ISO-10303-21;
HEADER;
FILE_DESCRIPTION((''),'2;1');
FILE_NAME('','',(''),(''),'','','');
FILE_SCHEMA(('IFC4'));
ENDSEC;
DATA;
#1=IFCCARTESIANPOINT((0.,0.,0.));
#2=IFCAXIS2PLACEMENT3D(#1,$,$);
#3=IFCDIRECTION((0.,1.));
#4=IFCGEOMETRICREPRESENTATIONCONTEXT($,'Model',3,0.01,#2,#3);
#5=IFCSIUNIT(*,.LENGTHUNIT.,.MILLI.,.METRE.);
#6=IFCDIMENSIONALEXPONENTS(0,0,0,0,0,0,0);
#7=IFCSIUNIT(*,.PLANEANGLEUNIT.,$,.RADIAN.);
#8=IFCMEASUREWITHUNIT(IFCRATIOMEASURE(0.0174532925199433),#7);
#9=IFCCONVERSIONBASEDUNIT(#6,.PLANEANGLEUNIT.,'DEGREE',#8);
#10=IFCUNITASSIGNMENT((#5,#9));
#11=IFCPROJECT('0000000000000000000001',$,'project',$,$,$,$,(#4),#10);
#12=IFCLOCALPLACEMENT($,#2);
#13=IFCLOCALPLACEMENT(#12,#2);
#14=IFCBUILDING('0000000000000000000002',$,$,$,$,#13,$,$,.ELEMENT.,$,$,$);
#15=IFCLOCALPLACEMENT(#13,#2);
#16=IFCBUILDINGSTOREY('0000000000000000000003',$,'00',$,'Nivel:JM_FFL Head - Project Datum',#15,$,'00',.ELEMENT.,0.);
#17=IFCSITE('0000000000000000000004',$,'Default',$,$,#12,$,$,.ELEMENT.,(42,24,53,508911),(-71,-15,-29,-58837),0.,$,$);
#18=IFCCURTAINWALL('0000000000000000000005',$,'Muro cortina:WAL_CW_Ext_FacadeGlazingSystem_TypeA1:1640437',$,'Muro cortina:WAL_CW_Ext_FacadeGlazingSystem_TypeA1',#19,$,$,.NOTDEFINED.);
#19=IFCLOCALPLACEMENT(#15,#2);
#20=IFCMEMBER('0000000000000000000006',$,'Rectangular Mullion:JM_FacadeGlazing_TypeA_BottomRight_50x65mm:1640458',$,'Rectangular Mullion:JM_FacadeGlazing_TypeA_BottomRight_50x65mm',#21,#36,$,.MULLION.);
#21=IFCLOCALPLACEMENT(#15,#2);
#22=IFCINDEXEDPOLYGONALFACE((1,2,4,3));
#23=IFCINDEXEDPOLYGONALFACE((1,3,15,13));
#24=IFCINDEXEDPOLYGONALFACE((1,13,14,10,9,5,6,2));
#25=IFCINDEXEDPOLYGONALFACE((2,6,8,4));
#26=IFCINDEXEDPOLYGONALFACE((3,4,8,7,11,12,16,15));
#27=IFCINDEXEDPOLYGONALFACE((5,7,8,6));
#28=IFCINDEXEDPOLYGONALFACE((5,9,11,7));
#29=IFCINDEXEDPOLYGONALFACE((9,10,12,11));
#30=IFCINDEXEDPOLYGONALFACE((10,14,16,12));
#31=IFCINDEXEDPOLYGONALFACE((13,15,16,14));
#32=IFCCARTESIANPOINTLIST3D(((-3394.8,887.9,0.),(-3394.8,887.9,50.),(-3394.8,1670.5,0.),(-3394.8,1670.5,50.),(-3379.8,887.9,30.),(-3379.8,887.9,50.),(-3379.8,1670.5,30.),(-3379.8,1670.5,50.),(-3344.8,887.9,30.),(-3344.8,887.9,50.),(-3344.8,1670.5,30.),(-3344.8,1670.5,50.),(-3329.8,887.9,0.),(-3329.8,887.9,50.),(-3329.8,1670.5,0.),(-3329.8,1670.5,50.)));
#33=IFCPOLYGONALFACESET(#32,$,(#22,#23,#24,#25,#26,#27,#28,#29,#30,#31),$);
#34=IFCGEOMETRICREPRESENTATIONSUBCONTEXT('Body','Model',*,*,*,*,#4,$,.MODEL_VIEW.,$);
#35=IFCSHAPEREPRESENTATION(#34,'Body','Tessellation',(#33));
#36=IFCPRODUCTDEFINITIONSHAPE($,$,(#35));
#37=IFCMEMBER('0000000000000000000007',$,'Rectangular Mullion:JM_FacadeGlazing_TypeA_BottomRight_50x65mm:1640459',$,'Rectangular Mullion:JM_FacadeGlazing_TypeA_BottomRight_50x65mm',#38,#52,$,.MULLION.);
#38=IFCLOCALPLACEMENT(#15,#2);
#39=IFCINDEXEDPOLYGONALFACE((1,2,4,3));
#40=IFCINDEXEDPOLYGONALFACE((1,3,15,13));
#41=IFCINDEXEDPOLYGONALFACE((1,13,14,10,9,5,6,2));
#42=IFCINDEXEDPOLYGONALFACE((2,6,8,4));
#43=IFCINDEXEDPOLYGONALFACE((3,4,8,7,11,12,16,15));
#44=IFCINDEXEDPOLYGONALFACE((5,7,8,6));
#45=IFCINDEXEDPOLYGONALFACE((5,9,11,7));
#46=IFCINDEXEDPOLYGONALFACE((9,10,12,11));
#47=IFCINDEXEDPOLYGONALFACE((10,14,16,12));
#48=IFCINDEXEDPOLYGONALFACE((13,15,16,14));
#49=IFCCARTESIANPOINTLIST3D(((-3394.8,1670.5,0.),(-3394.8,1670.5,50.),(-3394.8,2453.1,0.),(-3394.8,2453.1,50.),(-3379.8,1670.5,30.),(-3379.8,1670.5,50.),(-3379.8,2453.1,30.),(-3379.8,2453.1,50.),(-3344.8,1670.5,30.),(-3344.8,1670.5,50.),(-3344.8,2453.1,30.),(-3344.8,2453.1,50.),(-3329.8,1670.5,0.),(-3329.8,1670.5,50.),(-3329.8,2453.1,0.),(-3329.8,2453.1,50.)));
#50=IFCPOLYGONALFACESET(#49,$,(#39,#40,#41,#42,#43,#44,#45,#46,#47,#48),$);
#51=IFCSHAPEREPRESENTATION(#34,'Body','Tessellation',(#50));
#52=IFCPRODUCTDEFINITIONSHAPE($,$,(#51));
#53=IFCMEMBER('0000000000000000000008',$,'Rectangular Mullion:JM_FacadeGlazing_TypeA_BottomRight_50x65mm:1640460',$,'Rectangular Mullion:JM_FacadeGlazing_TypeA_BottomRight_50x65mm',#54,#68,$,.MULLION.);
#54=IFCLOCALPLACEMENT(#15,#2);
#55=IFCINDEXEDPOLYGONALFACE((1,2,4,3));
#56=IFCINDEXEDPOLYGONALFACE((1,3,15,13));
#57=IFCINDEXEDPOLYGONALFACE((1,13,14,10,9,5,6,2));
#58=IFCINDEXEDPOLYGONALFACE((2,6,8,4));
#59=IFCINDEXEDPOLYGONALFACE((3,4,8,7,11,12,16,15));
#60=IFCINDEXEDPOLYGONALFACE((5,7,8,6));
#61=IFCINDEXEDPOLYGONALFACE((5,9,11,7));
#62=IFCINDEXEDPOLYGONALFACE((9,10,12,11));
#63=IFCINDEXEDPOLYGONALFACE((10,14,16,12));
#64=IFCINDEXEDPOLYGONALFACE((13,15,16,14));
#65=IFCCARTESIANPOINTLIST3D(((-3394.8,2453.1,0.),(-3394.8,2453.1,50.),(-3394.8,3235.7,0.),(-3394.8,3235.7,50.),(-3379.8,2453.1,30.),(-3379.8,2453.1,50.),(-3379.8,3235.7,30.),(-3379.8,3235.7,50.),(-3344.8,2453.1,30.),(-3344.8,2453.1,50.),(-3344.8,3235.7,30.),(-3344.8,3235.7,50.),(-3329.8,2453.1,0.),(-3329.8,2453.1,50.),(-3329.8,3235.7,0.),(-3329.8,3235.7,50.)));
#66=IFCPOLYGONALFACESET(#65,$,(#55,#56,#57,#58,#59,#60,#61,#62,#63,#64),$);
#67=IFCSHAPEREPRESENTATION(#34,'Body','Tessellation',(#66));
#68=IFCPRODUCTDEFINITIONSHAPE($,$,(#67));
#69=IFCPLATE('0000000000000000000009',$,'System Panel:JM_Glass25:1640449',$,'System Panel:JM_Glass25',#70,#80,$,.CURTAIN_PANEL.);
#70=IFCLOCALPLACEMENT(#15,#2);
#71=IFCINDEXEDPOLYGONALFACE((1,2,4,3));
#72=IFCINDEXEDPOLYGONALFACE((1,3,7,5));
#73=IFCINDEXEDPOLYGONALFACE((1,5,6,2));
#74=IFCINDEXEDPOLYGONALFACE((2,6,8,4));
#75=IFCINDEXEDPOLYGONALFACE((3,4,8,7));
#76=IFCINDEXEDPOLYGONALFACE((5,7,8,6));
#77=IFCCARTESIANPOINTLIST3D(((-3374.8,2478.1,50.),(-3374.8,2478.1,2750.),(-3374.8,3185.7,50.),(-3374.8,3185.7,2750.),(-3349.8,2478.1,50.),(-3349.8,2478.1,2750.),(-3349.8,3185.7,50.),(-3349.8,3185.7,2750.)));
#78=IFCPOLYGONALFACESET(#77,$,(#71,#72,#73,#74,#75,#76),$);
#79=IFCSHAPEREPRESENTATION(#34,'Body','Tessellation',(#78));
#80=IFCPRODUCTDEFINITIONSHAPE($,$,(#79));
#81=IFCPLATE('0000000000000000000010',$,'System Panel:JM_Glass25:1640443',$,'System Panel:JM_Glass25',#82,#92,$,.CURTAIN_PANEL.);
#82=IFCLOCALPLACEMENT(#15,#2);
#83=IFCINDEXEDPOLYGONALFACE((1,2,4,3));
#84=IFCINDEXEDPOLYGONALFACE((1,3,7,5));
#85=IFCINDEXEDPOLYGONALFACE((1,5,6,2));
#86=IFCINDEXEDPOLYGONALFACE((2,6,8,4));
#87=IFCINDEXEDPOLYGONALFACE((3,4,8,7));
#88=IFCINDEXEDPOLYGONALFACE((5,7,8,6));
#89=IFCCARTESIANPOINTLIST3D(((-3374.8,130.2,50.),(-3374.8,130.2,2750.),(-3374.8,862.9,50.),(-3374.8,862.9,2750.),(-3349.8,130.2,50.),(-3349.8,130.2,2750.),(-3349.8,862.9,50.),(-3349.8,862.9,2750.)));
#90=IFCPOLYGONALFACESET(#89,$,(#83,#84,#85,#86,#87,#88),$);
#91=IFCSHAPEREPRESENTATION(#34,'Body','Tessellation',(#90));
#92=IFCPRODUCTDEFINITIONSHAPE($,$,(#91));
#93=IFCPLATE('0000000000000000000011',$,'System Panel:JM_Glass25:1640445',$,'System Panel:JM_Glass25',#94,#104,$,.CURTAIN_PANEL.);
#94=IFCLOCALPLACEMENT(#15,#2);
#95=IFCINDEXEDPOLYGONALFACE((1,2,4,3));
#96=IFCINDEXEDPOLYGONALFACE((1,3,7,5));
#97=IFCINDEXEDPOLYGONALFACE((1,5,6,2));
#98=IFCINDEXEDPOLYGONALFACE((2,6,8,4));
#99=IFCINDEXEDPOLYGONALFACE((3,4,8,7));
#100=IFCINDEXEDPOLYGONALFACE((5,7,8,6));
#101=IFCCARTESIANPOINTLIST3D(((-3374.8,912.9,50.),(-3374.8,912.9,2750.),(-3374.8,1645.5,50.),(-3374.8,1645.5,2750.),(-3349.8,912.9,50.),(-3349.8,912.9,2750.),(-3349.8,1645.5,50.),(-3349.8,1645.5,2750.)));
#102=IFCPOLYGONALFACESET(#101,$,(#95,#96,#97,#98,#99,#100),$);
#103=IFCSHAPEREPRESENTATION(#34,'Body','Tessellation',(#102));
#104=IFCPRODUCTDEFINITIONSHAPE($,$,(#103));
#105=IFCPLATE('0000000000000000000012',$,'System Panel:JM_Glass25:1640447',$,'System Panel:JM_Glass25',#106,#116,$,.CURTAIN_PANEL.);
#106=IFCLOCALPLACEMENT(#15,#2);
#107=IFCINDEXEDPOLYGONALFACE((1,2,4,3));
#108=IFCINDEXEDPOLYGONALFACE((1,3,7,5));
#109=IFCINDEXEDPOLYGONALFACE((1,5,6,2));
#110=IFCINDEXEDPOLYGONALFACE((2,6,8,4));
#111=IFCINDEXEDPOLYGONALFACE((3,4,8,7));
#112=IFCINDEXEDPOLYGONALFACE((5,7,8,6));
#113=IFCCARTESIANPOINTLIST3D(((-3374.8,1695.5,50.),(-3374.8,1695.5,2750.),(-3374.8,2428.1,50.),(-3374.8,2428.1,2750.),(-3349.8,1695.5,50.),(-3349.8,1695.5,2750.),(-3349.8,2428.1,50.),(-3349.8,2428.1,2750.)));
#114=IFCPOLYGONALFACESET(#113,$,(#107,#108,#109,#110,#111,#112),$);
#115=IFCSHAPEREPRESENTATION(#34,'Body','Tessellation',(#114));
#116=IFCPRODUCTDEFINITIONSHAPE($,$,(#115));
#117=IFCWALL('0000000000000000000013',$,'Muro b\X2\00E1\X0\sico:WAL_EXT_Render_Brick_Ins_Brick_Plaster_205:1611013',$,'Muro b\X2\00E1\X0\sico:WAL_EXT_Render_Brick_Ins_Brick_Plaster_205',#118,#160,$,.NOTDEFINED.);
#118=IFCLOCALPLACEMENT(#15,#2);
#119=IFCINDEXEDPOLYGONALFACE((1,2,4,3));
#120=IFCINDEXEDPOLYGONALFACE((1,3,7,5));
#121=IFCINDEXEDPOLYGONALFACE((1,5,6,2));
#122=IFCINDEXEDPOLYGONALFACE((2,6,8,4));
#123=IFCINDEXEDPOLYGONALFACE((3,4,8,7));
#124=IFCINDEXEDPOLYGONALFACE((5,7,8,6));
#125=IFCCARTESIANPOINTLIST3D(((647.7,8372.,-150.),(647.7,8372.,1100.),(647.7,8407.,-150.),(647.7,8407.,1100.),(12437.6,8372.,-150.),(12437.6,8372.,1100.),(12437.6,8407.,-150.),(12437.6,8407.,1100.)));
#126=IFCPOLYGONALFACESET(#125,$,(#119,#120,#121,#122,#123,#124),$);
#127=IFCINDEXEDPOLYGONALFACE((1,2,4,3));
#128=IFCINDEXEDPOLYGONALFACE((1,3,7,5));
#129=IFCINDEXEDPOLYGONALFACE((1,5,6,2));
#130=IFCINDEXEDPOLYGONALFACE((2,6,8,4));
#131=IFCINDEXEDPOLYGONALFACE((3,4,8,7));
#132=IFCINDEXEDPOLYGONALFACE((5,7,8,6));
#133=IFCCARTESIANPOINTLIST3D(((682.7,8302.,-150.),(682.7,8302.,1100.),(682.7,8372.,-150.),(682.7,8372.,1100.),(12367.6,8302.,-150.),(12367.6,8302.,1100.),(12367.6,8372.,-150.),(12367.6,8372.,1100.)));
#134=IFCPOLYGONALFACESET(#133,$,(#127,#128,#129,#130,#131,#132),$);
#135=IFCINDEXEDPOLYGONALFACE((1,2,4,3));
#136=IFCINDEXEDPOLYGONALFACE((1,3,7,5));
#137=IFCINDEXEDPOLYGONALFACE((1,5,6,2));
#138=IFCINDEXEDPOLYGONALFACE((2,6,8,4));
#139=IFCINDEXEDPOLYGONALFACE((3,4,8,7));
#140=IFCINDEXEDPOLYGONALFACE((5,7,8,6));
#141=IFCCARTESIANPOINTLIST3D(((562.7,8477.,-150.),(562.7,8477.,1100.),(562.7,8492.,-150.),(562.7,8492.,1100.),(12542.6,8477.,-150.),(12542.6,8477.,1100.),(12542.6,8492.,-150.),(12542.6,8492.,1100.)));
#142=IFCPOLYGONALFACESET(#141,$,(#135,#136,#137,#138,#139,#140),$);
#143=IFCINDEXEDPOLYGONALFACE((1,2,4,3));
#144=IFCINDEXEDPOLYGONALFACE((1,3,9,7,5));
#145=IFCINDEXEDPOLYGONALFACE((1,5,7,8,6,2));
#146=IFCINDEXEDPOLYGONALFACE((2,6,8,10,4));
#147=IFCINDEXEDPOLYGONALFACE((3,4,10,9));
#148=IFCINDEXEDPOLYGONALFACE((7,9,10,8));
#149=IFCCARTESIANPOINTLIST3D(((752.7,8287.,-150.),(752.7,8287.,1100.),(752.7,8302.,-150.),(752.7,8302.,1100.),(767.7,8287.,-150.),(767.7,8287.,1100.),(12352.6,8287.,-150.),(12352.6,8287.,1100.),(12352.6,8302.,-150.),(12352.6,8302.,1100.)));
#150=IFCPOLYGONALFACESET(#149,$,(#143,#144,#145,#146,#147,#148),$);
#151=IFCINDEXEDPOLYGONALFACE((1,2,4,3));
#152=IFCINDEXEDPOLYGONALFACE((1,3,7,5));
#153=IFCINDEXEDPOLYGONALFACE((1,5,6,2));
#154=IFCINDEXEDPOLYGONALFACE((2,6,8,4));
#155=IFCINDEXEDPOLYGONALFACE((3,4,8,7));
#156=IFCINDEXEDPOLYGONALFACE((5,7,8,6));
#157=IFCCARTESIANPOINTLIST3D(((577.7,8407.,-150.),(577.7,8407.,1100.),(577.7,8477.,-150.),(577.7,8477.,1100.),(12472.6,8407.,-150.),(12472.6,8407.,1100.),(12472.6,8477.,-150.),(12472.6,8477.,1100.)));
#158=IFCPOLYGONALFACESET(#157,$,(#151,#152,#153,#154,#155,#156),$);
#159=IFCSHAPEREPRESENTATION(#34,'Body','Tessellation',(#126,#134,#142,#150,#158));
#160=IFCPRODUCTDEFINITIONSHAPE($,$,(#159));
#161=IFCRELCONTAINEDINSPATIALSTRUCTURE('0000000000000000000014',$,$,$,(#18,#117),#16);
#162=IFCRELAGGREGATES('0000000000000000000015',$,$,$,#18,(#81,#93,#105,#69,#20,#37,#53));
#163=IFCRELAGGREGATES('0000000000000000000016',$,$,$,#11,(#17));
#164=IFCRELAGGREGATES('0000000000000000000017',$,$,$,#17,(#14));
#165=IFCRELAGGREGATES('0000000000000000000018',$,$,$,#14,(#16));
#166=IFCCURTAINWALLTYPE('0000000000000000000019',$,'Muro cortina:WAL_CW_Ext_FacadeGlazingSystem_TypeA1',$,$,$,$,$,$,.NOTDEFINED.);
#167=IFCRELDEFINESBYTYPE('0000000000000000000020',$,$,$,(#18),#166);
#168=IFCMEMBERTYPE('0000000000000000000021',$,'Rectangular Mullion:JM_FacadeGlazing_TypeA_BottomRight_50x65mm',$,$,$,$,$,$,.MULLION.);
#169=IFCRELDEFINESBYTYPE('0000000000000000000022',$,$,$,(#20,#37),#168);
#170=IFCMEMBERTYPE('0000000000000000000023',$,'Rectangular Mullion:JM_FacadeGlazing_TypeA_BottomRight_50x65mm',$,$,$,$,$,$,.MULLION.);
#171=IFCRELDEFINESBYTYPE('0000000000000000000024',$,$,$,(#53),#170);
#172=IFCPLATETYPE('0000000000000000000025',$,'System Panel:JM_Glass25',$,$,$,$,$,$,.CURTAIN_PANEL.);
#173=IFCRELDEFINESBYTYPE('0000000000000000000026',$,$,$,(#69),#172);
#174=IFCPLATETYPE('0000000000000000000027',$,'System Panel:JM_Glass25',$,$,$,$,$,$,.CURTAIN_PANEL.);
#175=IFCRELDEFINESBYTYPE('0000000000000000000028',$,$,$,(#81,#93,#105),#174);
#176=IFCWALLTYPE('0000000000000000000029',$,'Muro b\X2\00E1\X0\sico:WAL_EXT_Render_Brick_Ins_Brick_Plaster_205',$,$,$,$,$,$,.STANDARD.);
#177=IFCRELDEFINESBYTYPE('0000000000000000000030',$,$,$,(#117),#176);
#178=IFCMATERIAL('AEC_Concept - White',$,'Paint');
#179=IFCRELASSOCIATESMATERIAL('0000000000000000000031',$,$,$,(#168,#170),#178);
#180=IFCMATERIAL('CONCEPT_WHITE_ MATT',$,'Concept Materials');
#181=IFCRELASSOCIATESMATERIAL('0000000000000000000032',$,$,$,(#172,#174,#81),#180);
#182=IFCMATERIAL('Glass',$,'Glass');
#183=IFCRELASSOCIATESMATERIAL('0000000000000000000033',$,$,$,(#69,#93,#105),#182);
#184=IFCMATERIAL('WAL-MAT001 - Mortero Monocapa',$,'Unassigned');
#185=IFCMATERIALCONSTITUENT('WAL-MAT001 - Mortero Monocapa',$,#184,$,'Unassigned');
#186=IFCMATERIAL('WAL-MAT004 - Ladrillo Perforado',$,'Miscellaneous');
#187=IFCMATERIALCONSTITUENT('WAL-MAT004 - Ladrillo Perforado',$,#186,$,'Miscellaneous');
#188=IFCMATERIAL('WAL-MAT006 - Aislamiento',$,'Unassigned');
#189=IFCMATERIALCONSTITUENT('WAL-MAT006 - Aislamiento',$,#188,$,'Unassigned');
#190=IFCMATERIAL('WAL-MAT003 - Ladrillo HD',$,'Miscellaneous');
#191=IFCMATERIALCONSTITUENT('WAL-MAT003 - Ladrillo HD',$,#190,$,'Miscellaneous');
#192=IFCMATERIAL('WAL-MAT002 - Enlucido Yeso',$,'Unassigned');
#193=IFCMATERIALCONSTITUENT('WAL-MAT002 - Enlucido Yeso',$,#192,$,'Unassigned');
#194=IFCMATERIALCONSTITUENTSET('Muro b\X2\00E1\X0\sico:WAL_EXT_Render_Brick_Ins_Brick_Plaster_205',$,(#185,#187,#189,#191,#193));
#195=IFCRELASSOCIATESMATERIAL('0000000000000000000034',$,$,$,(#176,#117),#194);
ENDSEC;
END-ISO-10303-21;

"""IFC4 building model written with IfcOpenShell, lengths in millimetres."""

from ifc_helpers import new_model, entity, si_unit, converted_unit, direction, frame, origin, place, context, subcontext, project, spatial, indexed_curve, outline, extrude, source, transform, mapped, material, constituent, constituent_set, type_object, type_shapes, element, aggregate, save


model = new_model("IFC4")

# Units and contexts
model_context = context("Model", 3, precision=0.01, world=origin(), true_north=direction((0.0, 1.0)))
body_context = subcontext(model_context, "Body", "Model", "MODEL_VIEW")
ifc_project = project(units=[si_unit("LENGTHUNIT", "METRE", prefix="MILLI"), converted_unit("PLANEANGLEUNIT", "DEGREE", entity("IfcRatioMeasure", 0.0174532925199433), si_unit("PLANEANGLEUNIT", "RADIAN"), dimensions=[0, 0, 0, 0, 0, 0, 0])], contexts=[model_context])

# Site, building, storey
site_placement = place(None, origin())
site = spatial("IfcSite", under=ifc_project, at=site_placement, Name="Default", CompositionType="ELEMENT", RefLatitude=(42, 24, 53, 508911), RefLongitude=(-71, -15, -29, -58837), RefElevation=0.0)
building_placement = place(site_placement, origin())
building = spatial("IfcBuilding", under=site, at=building_placement, CompositionType="ELEMENT")
storey_placement = place(building_placement, origin())
storey = spatial("IfcBuildingStorey", under=building, at=storey_placement, Name="00", ObjectType="Nivel:JM_FFL Head - Project Datum", LongName="00", CompositionType="ELEMENT", Elevation=0.0)

# Curtain wall, members, plates
curtain_wall_type = type_object("IfcCurtainWallType", Name="Muro cortina:WAL_CW_Ext_FacadeGlazingSystem_TypeA1", PredefinedType="NOTDEFINED")
curtain_wall_placement = place(storey_placement, origin())
curtain_wall = element("IfcCurtainWall", 1, at=curtain_wall_placement, inside=storey, type_object=curtain_wall_type, Name="Muro cortina:WAL_CW_Ext_FacadeGlazingSystem_TypeA1:1640437", ObjectType="Muro cortina:WAL_CW_Ext_FacadeGlazingSystem_TypeA1", PredefinedType="NOTDEFINED")
ifc_material_1 = material(Name="AEC_Concept - White", Category="Paint")
member_type_1 = type_object("IfcMemberType", Name="Rectangular Mullion:JM_FacadeGlazing_TypeA_BottomRight_50x65mm", PredefinedType="MULLION", material=ifc_material_1)
shared_shape_1 = source(origin(), body_context, "Body", "SweptSolid", [
    extrude(outline(indexed_curve([(-32.5, -17.5), (-17.5, -17.5), (-17.5, 2.5), (17.5, 2.5), (17.5, -17.5), (32.5, -17.5), (32.5, 32.5), (-32.5, 32.5), (-32.5, -17.5)], self_intersect=False)), frame((-32.5, -32.5, -782.6), z_axis=(0.0, 0.0, 1.0), x_axis=(0.0, -1.0, 0.0)), (0.0, 0.0, 1.0), 782.6),
])
type_shapes(member_type_1, [shared_shape_1])
member_1_placement = place(curtain_wall_placement, frame((-3329.8, 887.9, 0.0), z_axis=(0.0, -1.0, 0.0), x_axis=(0.0, 0.0, -1.0)))
member_1 = element("IfcMember", 2, at=member_1_placement, type_object=member_type_1, Name="Rectangular Mullion:JM_FacadeGlazing_TypeA_BottomRight_50x65mm:1640458", ObjectType="Rectangular Mullion:JM_FacadeGlazing_TypeA_BottomRight_50x65mm", PredefinedType="MULLION", context=body_context, shape_type="MappedRepresentation", body=[
    mapped(shared_shape_1, transform((0.0, 0.0, 0.0), scale=1.0)),
])
member_2_placement = place(curtain_wall_placement, frame((-3329.8, 1670.5, 0.0), z_axis=(0.0, -1.0, 0.0), x_axis=(0.0, 0.0, -1.0)))
member_2 = element("IfcMember", 3, at=member_2_placement, type_object=member_type_1, Name="Rectangular Mullion:JM_FacadeGlazing_TypeA_BottomRight_50x65mm:1640459", ObjectType="Rectangular Mullion:JM_FacadeGlazing_TypeA_BottomRight_50x65mm", PredefinedType="MULLION", context=body_context, shape_type="MappedRepresentation", body=[
    mapped(shared_shape_1, transform((0.0, 0.0, 0.0), scale=1.0)),
])
member_type_2 = type_object("IfcMemberType", Name="Rectangular Mullion:JM_FacadeGlazing_TypeA_BottomRight_50x65mm", PredefinedType="MULLION", material=ifc_material_1)
shared_shape_2 = source(origin(), body_context, "Body", "SweptSolid", [
    extrude(outline(indexed_curve([(-32.5, -17.5), (-17.5, -17.5), (-17.5, 2.5), (17.5, 2.5), (17.5, -17.5), (32.5, -17.5), (32.5, 32.5), (-32.5, 32.5), (-32.5, -17.5)], self_intersect=False)), frame((-32.5, -32.5, -782.6), z_axis=(0.0, 0.0, 1.0), x_axis=(0.0, -1.0, 0.0)), (0.0, 0.0, 1.0), 782.6),
])
type_shapes(member_type_2, [shared_shape_2])
member_3_placement = place(curtain_wall_placement, frame((-3329.8, 2453.1, 0.0), z_axis=(0.0, -1.0, 0.0), x_axis=(0.0, 0.0, -1.0)))
member_3 = element("IfcMember", 4, at=member_3_placement, type_object=member_type_2, Name="Rectangular Mullion:JM_FacadeGlazing_TypeA_BottomRight_50x65mm:1640460", ObjectType="Rectangular Mullion:JM_FacadeGlazing_TypeA_BottomRight_50x65mm", PredefinedType="MULLION", context=body_context, shape_type="MappedRepresentation", body=[
    mapped(shared_shape_2, transform((0.0, 0.0, 0.0), scale=1.0)),
])
ifc_material_2 = material(Name="Glass", Category="Glass")
ifc_material_3 = material(Name="CONCEPT_WHITE_ MATT", Category="Concept Materials")
plate_type_1 = type_object("IfcPlateType", Name="System Panel:JM_Glass25", PredefinedType="CURTAIN_PANEL", material=ifc_material_3)
shared_shape_3 = source(origin(), body_context, "Body", "SweptSolid", [
    extrude(outline(indexed_curve([(-12.5, -353.8), (12.5, -353.8), (12.5, 353.8), (-12.5, 353.8), (-12.5, -353.8)], self_intersect=False)), frame((0.0, 32.5, 0.0), z_axis=(0.0, 0.0, 1.0), x_axis=(0.0, 1.0, 0.0)), (0.0, 0.0, 1.0), 2700.0),
])
type_shapes(plate_type_1, [shared_shape_3])
plate_1_placement = place(curtain_wall_placement, frame((-3329.8, 2831.9, 50.0), z_axis=(0.0, 0.0, 1.0), x_axis=(0.0, 1.0, 0.0)))
plate_1 = element("IfcPlate", 5, at=plate_1_placement, type_object=plate_type_1, material=ifc_material_2, Name="System Panel:JM_Glass25:1640449", ObjectType="System Panel:JM_Glass25", PredefinedType="CURTAIN_PANEL", context=body_context, shape_type="MappedRepresentation", body=[
    mapped(shared_shape_3, transform((0.0, 0.0, 0.0), scale=1.0)),
])
plate_type_2 = type_object("IfcPlateType", Name="System Panel:JM_Glass25", PredefinedType="CURTAIN_PANEL", material=ifc_material_3)
shared_shape_4 = source(origin(), body_context, "Body", "SweptSolid", [
    extrude(outline(indexed_curve([(-12.5, -366.3), (12.5, -366.3), (12.5, 366.3), (-12.5, 366.3), (-12.5, -366.3)], self_intersect=False)), frame((0.0, 32.5, 0.0), z_axis=(0.0, 0.0, 1.0), x_axis=(0.0, 1.0, 0.0)), (0.0, 0.0, 1.0), 2700.0),
])
type_shapes(plate_type_2, [shared_shape_4])
plate_2_placement = place(curtain_wall_placement, frame((-3329.8, 496.5, 50.0), z_axis=(0.0, 0.0, 1.0), x_axis=(0.0, 1.0, 0.0)))
plate_2 = element("IfcPlate", 6, at=plate_2_placement, type_object=plate_type_2, material=ifc_material_3, Name="System Panel:JM_Glass25:1640443", ObjectType="System Panel:JM_Glass25", PredefinedType="CURTAIN_PANEL", context=body_context, shape_type="MappedRepresentation", body=[
    mapped(shared_shape_4, transform((0.0, 0.0, 0.0), scale=1.0)),
])
plate_3_placement = place(curtain_wall_placement, frame((-3329.8, 1279.2, 50.0), z_axis=(0.0, 0.0, 1.0), x_axis=(0.0, 1.0, 0.0)))
plate_3 = element("IfcPlate", 7, at=plate_3_placement, type_object=plate_type_2, material=ifc_material_2, Name="System Panel:JM_Glass25:1640445", ObjectType="System Panel:JM_Glass25", PredefinedType="CURTAIN_PANEL", context=body_context, shape_type="MappedRepresentation", body=[
    mapped(shared_shape_4, transform((0.0, 0.0, 0.0), scale=1.0)),
])
plate_4_placement = place(curtain_wall_placement, frame((-3329.8, 2061.8, 50.0), z_axis=(0.0, 0.0, 1.0), x_axis=(0.0, 1.0, 0.0)))
plate_4 = element("IfcPlate", 8, at=plate_4_placement, type_object=plate_type_2, material=ifc_material_2, Name="System Panel:JM_Glass25:1640447", ObjectType="System Panel:JM_Glass25", PredefinedType="CURTAIN_PANEL", context=body_context, shape_type="MappedRepresentation", body=[
    mapped(shared_shape_4, transform((0.0, 0.0, 0.0), scale=1.0)),
])
aggregate(curtain_wall, [plate_2, plate_3, plate_4, plate_1, member_1, member_2, member_3])

# Wall
ifc_material_4 = material(Name="WAL-MAT001 - Mortero Monocapa", Category="Unassigned")
ifc_constituent_1 = constituent(ifc_material_4, Name="WAL-MAT001 - Mortero Monocapa", Category="Unassigned")
ifc_material_5 = material(Name="WAL-MAT004 - Ladrillo Perforado", Category="Miscellaneous")
ifc_constituent_2 = constituent(ifc_material_5, Name="WAL-MAT004 - Ladrillo Perforado", Category="Miscellaneous")
ifc_material_6 = material(Name="WAL-MAT006 - Aislamiento", Category="Unassigned")
ifc_constituent_3 = constituent(ifc_material_6, Name="WAL-MAT006 - Aislamiento", Category="Unassigned")
ifc_material_7 = material(Name="WAL-MAT003 - Ladrillo HD", Category="Miscellaneous")
ifc_constituent_4 = constituent(ifc_material_7, Name="WAL-MAT003 - Ladrillo HD", Category="Miscellaneous")
ifc_material_8 = material(Name="WAL-MAT002 - Enlucido Yeso", Category="Unassigned")
ifc_constituent_5 = constituent(ifc_material_8, Name="WAL-MAT002 - Enlucido Yeso", Category="Unassigned")
ifc_constituent_set_1 = constituent_set(constituents=[ifc_constituent_1, ifc_constituent_2, ifc_constituent_3, ifc_constituent_4, ifc_constituent_5], Name="Muro básico:WAL_EXT_Render_Brick_Ins_Brick_Plaster_205")
wall_type_1 = type_object("IfcWallType", Name="Muro básico:WAL_EXT_Render_Brick_Ins_Brick_Plaster_205", PredefinedType="STANDARD", material=ifc_constituent_set_1)
wall_1_placement = place(storey_placement, frame((562.7, 8389.5, -150.0)))
element("IfcWall", 9, at=wall_1_placement, inside=storey, type_object=wall_type_1, material=ifc_constituent_set_1, Name="Muro básico:WAL_EXT_Render_Brick_Ins_Brick_Plaster_205:1611013", ObjectType="Muro básico:WAL_EXT_Render_Brick_Ins_Brick_Plaster_205", PredefinedType="NOTDEFINED", context=body_context, shape_type="SweptSolid", body=[
    extrude(outline(indexed_curve([(-5894.9, -17.5), (5894.9, -17.5), (5894.9, 17.5), (-5894.9, 17.5), (-5894.9, -17.5)], self_intersect=False)), frame((5979.9, 0.0, 0.0)), (0.0, 0.0, 1.0), 1250.0),
    extrude(outline(indexed_curve([(-5842.4, -35.0), (5842.4, -35.0), (5842.4, 35.0), (-5842.4, 35.0), (-5842.4, -35.0)], self_intersect=False)), frame((5962.4, -52.5, 0.0)), (0.0, 0.0, 1.0), 1250.0),
    extrude(outline(indexed_curve([(-7.5, -5989.9), (7.5, -5989.9), (7.5, 5989.9), (-7.5, 5989.9), (-7.5, -5989.9)], self_intersect=False)), frame((5989.9, 95.0, 0.0), z_axis=(0.0, 0.0, 1.0), x_axis=(0.0, -1.0, 0.0)), (0.0, 0.0, 1.0), 1250.0),
    extrude(outline(indexed_curve([(-4627.9, -6.0), (6956.9, -6.0), (6956.9, 9.0), (-4642.9, 9.0), (-4642.9, -6.0), (-4627.9, -6.0)], self_intersect=False)), frame((4832.9, -96.5, 0.0)), (0.0, 0.0, 1.0), 1250.0),
    extrude(outline(indexed_curve([(-5947.4, -35.0), (5947.4, -35.0), (5947.4, 35.0), (-5947.4, 35.0), (-5947.4, -35.0)], self_intersect=False)), frame((5962.4, 52.5, 0.0)), (0.0, 0.0, 1.0), 1250.0),
])

save(model, "model.ifc")
